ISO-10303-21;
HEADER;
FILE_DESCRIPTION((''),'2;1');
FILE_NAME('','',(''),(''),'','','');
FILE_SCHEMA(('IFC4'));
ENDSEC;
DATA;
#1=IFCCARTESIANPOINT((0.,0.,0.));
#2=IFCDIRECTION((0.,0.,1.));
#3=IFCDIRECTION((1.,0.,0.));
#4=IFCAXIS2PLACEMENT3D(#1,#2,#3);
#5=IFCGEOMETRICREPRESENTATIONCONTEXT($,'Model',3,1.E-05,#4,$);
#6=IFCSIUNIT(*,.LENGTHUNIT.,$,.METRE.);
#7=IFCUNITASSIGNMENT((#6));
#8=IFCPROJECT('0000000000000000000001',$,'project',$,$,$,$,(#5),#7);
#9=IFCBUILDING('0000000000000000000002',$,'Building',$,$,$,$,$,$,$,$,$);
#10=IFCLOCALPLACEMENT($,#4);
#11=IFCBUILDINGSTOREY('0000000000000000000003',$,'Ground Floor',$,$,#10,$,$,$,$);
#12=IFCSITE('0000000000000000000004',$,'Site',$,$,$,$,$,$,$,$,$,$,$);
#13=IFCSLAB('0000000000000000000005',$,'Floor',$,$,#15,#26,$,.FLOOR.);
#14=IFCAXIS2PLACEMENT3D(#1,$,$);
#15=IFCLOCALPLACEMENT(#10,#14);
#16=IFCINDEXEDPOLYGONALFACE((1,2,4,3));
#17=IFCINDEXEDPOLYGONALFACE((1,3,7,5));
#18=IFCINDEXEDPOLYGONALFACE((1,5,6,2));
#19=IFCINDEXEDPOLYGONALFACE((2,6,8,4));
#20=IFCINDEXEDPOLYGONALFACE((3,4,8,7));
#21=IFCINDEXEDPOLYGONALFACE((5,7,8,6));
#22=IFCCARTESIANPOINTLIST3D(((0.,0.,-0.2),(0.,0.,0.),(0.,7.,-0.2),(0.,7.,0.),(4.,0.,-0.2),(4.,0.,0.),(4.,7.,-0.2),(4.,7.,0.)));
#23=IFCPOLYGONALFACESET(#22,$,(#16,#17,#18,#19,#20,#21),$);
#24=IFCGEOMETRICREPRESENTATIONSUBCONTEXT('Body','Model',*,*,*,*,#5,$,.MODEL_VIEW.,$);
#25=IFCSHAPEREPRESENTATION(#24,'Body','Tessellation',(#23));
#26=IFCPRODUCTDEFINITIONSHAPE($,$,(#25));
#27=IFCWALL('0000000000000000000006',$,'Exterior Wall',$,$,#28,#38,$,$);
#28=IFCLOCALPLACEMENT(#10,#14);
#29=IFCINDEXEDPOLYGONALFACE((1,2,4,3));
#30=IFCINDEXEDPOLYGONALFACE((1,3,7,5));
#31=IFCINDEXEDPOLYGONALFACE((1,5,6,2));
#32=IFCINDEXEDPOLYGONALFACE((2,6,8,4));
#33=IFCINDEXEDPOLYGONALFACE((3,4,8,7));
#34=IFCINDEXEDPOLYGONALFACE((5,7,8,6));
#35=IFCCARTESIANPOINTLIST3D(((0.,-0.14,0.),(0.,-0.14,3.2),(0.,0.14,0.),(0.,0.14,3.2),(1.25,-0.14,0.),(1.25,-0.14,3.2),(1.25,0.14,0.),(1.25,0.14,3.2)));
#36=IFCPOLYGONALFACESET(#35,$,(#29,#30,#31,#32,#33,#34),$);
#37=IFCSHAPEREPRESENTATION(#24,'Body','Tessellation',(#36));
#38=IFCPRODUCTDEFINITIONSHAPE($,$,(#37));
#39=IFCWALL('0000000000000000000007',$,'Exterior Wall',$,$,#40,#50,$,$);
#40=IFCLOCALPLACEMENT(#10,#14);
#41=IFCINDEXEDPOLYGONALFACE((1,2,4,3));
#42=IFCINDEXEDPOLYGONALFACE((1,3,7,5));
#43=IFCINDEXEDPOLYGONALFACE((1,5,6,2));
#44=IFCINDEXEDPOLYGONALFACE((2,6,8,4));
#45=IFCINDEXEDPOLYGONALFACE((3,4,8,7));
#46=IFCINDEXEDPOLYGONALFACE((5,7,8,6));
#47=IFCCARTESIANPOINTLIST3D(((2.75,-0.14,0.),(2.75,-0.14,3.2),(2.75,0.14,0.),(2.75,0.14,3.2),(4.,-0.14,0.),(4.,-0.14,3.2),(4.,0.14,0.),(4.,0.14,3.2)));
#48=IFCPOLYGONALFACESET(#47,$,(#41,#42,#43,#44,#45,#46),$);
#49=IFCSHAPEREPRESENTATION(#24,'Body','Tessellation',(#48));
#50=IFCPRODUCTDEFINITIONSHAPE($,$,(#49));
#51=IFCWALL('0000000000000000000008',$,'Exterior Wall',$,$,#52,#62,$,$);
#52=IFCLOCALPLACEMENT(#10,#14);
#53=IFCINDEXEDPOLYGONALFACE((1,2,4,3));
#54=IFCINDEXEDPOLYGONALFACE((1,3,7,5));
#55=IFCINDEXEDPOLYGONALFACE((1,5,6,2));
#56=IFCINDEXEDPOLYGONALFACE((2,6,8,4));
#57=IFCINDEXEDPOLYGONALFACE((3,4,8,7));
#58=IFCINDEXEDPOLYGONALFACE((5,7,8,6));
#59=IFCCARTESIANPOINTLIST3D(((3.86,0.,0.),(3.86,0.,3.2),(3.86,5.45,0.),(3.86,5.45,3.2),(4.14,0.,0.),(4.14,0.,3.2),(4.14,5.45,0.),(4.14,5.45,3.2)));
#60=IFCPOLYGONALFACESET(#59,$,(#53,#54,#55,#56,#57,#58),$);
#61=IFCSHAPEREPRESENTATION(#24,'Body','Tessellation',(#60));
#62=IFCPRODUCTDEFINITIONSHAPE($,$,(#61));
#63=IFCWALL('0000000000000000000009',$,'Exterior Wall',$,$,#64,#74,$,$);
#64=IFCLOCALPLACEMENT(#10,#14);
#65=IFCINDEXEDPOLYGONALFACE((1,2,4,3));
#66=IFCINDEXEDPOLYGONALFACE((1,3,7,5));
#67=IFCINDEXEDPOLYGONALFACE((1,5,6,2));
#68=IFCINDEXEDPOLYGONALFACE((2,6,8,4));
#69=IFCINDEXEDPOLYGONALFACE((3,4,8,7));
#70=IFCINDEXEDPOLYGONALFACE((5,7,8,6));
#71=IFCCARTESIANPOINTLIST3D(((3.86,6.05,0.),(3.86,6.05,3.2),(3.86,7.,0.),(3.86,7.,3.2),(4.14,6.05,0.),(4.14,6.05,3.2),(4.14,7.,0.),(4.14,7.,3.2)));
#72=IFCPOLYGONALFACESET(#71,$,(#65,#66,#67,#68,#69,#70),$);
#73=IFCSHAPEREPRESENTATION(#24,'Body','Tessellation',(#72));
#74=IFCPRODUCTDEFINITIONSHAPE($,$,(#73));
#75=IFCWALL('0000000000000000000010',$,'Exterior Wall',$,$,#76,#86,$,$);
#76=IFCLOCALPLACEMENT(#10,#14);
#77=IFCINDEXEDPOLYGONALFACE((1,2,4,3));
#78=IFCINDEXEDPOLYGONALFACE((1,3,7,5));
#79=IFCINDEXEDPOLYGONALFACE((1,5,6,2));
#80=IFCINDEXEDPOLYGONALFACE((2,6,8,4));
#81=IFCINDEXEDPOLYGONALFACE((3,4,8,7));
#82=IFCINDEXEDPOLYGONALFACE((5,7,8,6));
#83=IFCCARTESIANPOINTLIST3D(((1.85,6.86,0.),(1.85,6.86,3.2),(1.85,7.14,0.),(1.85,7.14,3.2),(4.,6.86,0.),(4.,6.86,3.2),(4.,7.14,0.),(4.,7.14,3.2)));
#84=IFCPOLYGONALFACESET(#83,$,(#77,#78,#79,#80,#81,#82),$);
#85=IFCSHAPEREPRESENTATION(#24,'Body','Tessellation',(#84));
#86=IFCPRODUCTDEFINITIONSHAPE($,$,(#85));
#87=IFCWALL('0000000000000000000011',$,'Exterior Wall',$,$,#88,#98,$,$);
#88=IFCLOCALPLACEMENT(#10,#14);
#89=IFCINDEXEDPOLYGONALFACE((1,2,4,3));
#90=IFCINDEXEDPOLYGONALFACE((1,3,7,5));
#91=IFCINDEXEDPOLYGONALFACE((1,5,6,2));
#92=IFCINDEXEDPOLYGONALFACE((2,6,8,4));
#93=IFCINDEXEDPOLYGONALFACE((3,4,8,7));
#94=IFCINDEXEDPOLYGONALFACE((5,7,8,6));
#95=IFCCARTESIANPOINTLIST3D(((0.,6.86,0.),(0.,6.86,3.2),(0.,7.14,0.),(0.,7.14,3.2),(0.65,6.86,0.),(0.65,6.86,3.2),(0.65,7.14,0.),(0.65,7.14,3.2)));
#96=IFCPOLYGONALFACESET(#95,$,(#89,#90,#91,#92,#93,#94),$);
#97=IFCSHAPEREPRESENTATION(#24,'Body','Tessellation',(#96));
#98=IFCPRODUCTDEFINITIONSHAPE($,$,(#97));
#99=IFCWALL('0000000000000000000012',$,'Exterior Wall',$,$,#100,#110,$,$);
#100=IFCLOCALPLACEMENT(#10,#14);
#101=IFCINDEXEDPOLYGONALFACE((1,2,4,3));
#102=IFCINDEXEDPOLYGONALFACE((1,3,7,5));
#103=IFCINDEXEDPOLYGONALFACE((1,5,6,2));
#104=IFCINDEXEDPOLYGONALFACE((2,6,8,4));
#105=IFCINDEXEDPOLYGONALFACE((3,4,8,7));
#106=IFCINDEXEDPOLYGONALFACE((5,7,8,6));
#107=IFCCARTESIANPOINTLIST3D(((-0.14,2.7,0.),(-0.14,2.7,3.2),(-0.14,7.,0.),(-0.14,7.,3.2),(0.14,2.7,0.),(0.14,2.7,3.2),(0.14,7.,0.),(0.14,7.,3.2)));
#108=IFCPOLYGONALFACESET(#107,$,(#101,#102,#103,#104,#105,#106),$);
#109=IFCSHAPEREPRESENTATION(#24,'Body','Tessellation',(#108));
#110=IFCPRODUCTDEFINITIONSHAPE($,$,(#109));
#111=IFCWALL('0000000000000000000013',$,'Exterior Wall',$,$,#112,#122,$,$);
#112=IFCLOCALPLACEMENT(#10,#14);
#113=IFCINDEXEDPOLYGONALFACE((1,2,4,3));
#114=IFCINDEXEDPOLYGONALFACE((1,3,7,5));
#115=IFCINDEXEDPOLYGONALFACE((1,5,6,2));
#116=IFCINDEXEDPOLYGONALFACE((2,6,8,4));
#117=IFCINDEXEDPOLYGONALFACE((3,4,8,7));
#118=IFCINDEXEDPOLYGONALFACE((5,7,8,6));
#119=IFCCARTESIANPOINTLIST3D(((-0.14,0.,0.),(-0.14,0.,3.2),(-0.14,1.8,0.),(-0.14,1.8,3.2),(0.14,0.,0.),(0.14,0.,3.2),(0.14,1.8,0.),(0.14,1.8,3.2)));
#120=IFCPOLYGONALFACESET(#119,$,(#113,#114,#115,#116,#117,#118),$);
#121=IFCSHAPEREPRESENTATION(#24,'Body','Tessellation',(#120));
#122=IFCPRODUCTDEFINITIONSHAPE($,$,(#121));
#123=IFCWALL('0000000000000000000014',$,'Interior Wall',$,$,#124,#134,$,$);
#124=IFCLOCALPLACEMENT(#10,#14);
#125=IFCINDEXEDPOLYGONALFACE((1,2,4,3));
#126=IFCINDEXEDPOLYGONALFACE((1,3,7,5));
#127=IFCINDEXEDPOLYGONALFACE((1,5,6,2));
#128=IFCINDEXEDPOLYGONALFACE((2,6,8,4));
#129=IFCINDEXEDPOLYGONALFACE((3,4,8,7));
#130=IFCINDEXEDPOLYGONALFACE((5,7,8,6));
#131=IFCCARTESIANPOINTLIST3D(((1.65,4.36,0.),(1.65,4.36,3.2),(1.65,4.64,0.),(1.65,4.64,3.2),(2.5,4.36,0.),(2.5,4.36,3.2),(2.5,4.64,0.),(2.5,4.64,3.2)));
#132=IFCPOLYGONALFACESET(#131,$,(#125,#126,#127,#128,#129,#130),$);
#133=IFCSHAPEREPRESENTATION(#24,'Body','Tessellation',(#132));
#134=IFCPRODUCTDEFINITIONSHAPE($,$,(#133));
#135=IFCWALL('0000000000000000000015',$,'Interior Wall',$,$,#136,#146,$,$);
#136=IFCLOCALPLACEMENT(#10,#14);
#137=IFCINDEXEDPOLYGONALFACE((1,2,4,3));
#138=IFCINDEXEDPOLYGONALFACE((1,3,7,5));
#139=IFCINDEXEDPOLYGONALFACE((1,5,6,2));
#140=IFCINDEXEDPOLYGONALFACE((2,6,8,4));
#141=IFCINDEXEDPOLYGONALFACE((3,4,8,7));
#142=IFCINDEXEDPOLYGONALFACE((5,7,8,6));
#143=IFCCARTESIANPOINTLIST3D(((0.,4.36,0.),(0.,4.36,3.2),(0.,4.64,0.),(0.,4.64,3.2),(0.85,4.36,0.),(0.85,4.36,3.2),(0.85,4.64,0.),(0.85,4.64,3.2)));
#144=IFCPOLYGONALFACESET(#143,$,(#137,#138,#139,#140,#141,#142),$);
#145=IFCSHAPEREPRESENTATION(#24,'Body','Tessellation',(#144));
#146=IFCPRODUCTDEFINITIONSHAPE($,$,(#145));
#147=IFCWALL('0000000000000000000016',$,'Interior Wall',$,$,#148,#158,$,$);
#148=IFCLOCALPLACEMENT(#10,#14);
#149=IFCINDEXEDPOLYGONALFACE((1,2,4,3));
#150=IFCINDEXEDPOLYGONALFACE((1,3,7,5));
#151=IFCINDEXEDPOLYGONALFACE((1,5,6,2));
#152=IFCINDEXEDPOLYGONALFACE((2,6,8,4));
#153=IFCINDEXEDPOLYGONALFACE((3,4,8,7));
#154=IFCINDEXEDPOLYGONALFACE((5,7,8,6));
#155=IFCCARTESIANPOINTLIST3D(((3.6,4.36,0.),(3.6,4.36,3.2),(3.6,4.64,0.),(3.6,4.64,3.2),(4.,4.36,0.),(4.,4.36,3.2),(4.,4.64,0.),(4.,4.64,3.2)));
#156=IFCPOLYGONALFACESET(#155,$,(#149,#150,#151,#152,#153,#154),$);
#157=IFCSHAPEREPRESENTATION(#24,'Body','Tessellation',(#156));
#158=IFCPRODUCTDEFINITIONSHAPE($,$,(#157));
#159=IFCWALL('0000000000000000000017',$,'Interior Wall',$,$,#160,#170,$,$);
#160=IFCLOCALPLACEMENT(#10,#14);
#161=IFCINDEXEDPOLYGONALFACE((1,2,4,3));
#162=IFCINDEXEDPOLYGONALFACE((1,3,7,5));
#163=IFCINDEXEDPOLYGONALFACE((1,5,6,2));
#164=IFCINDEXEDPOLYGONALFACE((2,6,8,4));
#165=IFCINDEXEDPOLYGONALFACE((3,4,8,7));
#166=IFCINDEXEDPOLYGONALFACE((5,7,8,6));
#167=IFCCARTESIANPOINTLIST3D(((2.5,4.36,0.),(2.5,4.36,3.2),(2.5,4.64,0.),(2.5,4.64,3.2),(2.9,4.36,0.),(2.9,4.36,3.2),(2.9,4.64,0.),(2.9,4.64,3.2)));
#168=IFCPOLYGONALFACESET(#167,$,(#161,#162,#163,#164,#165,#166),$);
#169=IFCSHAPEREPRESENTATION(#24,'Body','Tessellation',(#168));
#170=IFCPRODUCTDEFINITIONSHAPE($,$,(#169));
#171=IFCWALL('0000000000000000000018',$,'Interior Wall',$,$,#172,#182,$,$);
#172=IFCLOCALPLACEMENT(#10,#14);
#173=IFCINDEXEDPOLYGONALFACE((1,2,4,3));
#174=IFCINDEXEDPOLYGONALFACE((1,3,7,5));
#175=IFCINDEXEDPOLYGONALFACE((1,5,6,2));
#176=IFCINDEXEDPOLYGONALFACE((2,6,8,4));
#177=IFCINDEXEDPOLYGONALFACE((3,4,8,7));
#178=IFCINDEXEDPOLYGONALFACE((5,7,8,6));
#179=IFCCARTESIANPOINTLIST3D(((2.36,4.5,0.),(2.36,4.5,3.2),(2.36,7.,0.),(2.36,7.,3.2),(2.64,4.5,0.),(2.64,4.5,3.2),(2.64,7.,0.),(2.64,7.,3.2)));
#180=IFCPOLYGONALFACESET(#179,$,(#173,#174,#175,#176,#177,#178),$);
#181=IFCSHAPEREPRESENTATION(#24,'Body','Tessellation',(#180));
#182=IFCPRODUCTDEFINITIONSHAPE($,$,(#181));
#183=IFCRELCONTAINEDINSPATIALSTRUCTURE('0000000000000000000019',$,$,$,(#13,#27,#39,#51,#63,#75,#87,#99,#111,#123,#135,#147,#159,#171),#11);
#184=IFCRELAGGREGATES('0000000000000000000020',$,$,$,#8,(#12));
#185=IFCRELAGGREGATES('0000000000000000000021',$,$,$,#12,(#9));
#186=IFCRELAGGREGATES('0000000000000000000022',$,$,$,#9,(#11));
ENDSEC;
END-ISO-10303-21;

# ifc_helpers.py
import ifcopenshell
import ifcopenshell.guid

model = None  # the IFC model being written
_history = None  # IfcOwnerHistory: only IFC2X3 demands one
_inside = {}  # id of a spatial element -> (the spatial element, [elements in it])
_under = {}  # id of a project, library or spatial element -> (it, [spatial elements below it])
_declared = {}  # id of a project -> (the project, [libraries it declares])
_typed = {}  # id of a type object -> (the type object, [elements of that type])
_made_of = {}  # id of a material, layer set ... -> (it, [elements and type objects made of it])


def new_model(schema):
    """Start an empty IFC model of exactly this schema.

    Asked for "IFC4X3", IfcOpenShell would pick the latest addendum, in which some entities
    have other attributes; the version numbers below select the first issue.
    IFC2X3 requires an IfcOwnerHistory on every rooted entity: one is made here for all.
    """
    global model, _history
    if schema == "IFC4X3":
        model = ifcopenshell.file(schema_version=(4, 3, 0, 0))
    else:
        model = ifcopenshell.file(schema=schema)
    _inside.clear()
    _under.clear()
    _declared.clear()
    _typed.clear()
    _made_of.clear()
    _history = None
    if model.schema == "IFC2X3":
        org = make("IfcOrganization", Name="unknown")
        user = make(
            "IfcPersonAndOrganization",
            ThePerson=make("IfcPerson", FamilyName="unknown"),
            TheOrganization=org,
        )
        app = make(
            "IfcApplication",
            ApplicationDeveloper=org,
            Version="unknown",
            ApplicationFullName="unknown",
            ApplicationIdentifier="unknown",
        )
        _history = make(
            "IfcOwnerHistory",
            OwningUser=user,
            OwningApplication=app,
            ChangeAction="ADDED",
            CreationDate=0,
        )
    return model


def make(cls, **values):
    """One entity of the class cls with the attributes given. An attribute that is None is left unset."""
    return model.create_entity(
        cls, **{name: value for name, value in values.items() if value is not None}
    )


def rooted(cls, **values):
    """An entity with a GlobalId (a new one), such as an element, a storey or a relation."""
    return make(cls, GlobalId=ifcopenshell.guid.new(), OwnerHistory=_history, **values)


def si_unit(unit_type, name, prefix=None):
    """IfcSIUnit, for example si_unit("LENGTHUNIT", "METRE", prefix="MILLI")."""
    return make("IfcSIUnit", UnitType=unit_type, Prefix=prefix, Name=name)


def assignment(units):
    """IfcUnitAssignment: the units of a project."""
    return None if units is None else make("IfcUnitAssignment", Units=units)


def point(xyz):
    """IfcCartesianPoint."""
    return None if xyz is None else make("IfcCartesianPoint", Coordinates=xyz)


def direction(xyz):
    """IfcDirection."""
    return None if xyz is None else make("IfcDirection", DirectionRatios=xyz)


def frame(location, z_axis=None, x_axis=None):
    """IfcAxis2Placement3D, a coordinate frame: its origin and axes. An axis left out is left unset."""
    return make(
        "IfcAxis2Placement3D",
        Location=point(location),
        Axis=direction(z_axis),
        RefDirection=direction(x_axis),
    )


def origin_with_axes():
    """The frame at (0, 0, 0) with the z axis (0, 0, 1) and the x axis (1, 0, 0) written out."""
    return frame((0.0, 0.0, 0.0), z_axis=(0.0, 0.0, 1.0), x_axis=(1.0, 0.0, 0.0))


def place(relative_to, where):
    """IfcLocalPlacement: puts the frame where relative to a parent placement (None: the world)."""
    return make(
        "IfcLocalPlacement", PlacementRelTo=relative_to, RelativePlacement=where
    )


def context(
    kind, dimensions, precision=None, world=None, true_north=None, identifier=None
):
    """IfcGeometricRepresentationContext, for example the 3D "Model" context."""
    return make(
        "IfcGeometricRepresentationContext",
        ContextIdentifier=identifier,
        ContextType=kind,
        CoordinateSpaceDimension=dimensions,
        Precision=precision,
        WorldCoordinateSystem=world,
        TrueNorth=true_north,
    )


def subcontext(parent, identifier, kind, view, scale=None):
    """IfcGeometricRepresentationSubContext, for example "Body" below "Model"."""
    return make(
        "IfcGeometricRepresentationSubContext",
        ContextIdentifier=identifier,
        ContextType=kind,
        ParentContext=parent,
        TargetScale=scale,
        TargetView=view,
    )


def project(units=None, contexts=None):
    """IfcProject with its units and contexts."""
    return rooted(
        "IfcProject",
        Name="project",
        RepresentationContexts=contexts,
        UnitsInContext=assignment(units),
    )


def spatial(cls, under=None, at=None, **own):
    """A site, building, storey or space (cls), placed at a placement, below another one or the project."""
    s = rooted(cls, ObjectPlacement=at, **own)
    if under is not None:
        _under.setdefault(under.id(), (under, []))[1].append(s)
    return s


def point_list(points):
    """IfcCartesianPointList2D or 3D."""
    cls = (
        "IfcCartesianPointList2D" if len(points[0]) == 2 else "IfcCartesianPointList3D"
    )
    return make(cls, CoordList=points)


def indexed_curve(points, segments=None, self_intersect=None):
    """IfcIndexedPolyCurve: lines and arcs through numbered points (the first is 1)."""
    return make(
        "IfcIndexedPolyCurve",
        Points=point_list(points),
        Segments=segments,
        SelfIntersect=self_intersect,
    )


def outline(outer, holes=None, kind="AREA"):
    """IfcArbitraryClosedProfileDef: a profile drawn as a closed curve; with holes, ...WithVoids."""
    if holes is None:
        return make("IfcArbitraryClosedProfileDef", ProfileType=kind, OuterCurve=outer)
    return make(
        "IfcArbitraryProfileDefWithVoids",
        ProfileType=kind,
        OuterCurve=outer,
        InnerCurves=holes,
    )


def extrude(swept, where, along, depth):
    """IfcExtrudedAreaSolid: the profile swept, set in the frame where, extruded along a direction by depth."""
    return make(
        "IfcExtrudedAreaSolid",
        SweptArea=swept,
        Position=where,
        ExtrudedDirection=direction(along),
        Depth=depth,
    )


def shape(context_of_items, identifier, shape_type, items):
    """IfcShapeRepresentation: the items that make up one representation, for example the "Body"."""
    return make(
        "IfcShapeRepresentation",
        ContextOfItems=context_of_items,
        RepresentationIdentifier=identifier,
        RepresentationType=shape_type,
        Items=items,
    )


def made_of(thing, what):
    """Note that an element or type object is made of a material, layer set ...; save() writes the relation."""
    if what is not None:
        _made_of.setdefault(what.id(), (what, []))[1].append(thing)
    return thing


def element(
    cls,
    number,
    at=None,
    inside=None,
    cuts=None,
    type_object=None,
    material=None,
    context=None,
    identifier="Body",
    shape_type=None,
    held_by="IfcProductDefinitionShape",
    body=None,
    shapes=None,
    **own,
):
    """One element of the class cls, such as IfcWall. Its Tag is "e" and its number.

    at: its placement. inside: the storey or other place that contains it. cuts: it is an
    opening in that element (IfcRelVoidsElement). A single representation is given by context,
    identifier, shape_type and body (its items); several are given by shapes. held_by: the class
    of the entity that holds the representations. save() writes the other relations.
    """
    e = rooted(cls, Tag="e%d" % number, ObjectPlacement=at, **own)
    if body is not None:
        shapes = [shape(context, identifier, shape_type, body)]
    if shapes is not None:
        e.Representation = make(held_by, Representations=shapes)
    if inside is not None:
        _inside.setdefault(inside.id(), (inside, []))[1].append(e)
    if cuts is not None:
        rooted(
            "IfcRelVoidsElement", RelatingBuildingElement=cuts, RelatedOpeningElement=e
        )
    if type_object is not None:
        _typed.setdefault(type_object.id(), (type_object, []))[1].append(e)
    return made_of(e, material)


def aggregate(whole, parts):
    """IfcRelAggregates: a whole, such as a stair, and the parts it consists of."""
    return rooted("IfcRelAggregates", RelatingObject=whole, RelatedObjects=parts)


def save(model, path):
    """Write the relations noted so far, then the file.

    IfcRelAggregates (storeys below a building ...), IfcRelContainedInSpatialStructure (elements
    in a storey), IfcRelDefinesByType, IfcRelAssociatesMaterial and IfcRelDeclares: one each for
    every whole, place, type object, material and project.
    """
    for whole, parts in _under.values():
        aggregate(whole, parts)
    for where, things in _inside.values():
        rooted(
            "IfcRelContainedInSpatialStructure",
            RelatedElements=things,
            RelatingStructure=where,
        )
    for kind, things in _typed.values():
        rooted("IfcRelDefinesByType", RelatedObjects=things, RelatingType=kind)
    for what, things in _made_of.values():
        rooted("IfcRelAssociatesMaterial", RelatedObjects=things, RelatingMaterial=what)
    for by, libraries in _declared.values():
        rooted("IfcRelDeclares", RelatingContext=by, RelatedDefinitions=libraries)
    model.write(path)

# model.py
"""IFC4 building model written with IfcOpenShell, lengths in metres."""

from ifc_helpers import new_model, si_unit, frame, origin_with_axes, place, context, subcontext, project, spatial, indexed_curve, outline, extrude, element, save


model = new_model("IFC4")

# Units and contexts
model_context = context("Model", 3, precision=1e-05, world=origin_with_axes())
body_context = subcontext(model_context, "Body", "Model", "MODEL_VIEW")
ifc_project = project(units=[si_unit("LENGTHUNIT", "METRE")], contexts=[model_context])

# Site, building, storey
site = spatial("IfcSite", under=ifc_project, Name="Site")
building = spatial("IfcBuilding", under=site, Name="Building")
storey_placement = place(None, origin_with_axes())
storey = spatial("IfcBuildingStorey", under=building, at=storey_placement, Name="Ground Floor")

# Slab
slab_placement = place(storey_placement, frame((0.0, 0.0, -0.2), z_axis=(0.0, 0.0, 1.0), x_axis=(1.0, 0.0, 0.0)))
element("IfcSlab", 1, at=slab_placement, inside=storey, Name="Floor", PredefinedType="FLOOR", context=body_context, shape_type="SweptSolid", body=[
    extrude(outline(indexed_curve([(0.0, 0.0), (4.0, 0.0), (4.0, 7.0), (0.0, 7.0)])), None, (0.0, 0.0, 1.0), 0.2),
])

# Walls
for number, where, z_axis, x_axis, name in (
    (2, (0.0, 0.0, 0.0), (0.0, 0.0, 1.0), (1.0, 0.0, 0.0), "Exterior Wall"),
    (3, (2.75, 0.0, 0.0), (0.0, 0.0, 1.0), (1.0, 0.0, 0.0), "Exterior Wall"),
):
    element("IfcWall", number, at=place(storey_placement, frame(where, z_axis=z_axis, x_axis=x_axis)), inside=storey, Name=name, context=body_context, shape_type="SweptSolid", body=[
        extrude(outline(indexed_curve([(0.0, 0.0), (0.0, 0.28), (1.25, 0.28), (1.25, 0.0), (0.0, 0.0)], self_intersect=False)), frame((0.0, -0.14, 0.0), z_axis=(0.0, 0.0, 1.0), x_axis=(1.0, 0.0, 0.0)), (0.0, 0.0, 1.0), 3.2),
    ])
wall_1_placement = place(storey_placement, frame((4.0, 0.0, 0.0), z_axis=(0.0, 0.0, 1.0), x_axis=(0.0, 1.0, 0.0)))
element("IfcWall", 4, at=wall_1_placement, inside=storey, Name="Exterior Wall", context=body_context, shape_type="SweptSolid", body=[
    extrude(outline(indexed_curve([(0.0, 0.0), (0.0, 0.28), (5.45, 0.28), (5.45, 0.0), (0.0, 0.0)], self_intersect=False)), frame((0.0, -0.14, 0.0), z_axis=(0.0, 0.0, 1.0), x_axis=(1.0, 0.0, 0.0)), (0.0, 0.0, 1.0), 3.2),
])
wall_2_placement = place(storey_placement, frame((4.0, 6.05, 0.0), z_axis=(0.0, 0.0, 1.0), x_axis=(0.0, 1.0, 0.0)))
element("IfcWall", 5, at=wall_2_placement, inside=storey, Name="Exterior Wall", context=body_context, shape_type="SweptSolid", body=[
    extrude(outline(indexed_curve([(0.0, 0.0), (0.0, 0.28), (0.95, 0.28), (0.95, 0.0), (0.0, 0.0)], self_intersect=False)), frame((0.0, -0.14, 0.0), z_axis=(0.0, 0.0, 1.0), x_axis=(1.0, 0.0, 0.0)), (0.0, 0.0, 1.0), 3.2),
])
wall_3_placement = place(storey_placement, frame((4.0, 7.0, 0.0), z_axis=(0.0, 0.0, 1.0), x_axis=(-1.0, 0.0, 0.0)))
element("IfcWall", 6, at=wall_3_placement, inside=storey, Name="Exterior Wall", context=body_context, shape_type="SweptSolid", body=[
    extrude(outline(indexed_curve([(0.0, 0.0), (0.0, 0.28), (2.15, 0.28), (2.15, 0.0), (0.0, 0.0)], self_intersect=False)), frame((0.0, -0.14, 0.0), z_axis=(0.0, 0.0, 1.0), x_axis=(1.0, 0.0, 0.0)), (0.0, 0.0, 1.0), 3.2),
])
wall_4_placement = place(storey_placement, frame((0.65, 7.0, 0.0), z_axis=(0.0, 0.0, 1.0), x_axis=(-1.0, 0.0, 0.0)))
element("IfcWall", 7, at=wall_4_placement, inside=storey, Name="Exterior Wall", context=body_context, shape_type="SweptSolid", body=[
    extrude(outline(indexed_curve([(0.0, 0.0), (0.0, 0.28), (0.65, 0.28), (0.65, 0.0), (0.0, 0.0)], self_intersect=False)), frame((0.0, -0.14, 0.0), z_axis=(0.0, 0.0, 1.0), x_axis=(1.0, 0.0, 0.0)), (0.0, 0.0, 1.0), 3.2),
])
wall_5_placement = place(storey_placement, frame((0.0, 7.0, 0.0), z_axis=(0.0, 0.0, 1.0), x_axis=(0.0, -1.0, 0.0)))
element("IfcWall", 8, at=wall_5_placement, inside=storey, Name="Exterior Wall", context=body_context, shape_type="SweptSolid", body=[
    extrude(outline(indexed_curve([(0.0, 0.0), (0.0, 0.28), (4.3, 0.28), (4.3, 0.0), (0.0, 0.0)], self_intersect=False)), frame((0.0, -0.14, 0.0), z_axis=(0.0, 0.0, 1.0), x_axis=(1.0, 0.0, 0.0)), (0.0, 0.0, 1.0), 3.2),
])
wall_6_placement = place(storey_placement, frame((0.0, 1.8, 0.0), z_axis=(0.0, 0.0, 1.0), x_axis=(0.0, -1.0, 0.0)))
element("IfcWall", 9, at=wall_6_placement, inside=storey, Name="Exterior Wall", context=body_context, shape_type="SweptSolid", body=[
    extrude(outline(indexed_curve([(0.0, 0.0), (0.0, 0.28), (1.8, 0.28), (1.8, 0.0), (0.0, 0.0)], self_intersect=False)), frame((0.0, -0.14, 0.0), z_axis=(0.0, 0.0, 1.0), x_axis=(1.0, 0.0, 0.0)), (0.0, 0.0, 1.0), 3.2),
])
for number, where, z_axis, x_axis, name in (
    (10, (2.5, 4.5, 0.0), (0.0, 0.0, 1.0), (-1.0, 0.0, 0.0), "Interior Wall"),
    (11, (0.85, 4.5, 0.0), (0.0, 0.0, 1.0), (-1.0, 0.0, 0.0), "Interior Wall"),
):
    element("IfcWall", number, at=place(storey_placement, frame(where, z_axis=z_axis, x_axis=x_axis)), inside=storey, Name=name, context=body_context, shape_type="SweptSolid", body=[
        extrude(outline(indexed_curve([(0.0, 0.0), (0.0, 0.28), (0.85, 0.28), (0.85, 0.0), (0.0, 0.0)], self_intersect=False)), frame((0.0, -0.14, 0.0), z_axis=(0.0, 0.0, 1.0), x_axis=(1.0, 0.0, 0.0)), (0.0, 0.0, 1.0), 3.2),
    ])
for number, where, z_axis, x_axis, name in (
    (12, (4.0, 4.5, 0.0), (0.0, 0.0, 1.0), (-1.0, 0.0, 0.0), "Interior Wall"),
    (13, (2.9, 4.5, 0.0), (0.0, 0.0, 1.0), (-1.0, 0.0, 0.0), "Interior Wall"),
):
    element("IfcWall", number, at=place(storey_placement, frame(where, z_axis=z_axis, x_axis=x_axis)), inside=storey, Name=name, context=body_context, shape_type="SweptSolid", body=[
        extrude(outline(indexed_curve([(0.0, 0.0), (0.0, 0.28), (0.4, 0.28), (0.4, 0.0), (0.0, 0.0)], self_intersect=False)), frame((0.0, -0.14, 0.0), z_axis=(0.0, 0.0, 1.0), x_axis=(1.0, 0.0, 0.0)), (0.0, 0.0, 1.0), 3.2),
    ])
wall_7_placement = place(storey_placement, frame((2.5, 4.5, 0.0), z_axis=(0.0, 0.0, 1.0), x_axis=(0.0, 1.0, 0.0)))
element("IfcWall", 14, at=wall_7_placement, inside=storey, Name="Interior Wall", context=body_context, shape_type="SweptSolid", body=[
    extrude(outline(indexed_curve([(0.0, 0.0), (0.0, 0.28), (2.5, 0.28), (2.5, 0.0), (0.0, 0.0)], self_intersect=False)), frame((0.0, -0.14, 0.0), z_axis=(0.0, 0.0, 1.0), x_axis=(1.0, 0.0, 0.0)), (0.0, 0.0, 1.0), 3.2),
])

save(model, "model.ifc")
